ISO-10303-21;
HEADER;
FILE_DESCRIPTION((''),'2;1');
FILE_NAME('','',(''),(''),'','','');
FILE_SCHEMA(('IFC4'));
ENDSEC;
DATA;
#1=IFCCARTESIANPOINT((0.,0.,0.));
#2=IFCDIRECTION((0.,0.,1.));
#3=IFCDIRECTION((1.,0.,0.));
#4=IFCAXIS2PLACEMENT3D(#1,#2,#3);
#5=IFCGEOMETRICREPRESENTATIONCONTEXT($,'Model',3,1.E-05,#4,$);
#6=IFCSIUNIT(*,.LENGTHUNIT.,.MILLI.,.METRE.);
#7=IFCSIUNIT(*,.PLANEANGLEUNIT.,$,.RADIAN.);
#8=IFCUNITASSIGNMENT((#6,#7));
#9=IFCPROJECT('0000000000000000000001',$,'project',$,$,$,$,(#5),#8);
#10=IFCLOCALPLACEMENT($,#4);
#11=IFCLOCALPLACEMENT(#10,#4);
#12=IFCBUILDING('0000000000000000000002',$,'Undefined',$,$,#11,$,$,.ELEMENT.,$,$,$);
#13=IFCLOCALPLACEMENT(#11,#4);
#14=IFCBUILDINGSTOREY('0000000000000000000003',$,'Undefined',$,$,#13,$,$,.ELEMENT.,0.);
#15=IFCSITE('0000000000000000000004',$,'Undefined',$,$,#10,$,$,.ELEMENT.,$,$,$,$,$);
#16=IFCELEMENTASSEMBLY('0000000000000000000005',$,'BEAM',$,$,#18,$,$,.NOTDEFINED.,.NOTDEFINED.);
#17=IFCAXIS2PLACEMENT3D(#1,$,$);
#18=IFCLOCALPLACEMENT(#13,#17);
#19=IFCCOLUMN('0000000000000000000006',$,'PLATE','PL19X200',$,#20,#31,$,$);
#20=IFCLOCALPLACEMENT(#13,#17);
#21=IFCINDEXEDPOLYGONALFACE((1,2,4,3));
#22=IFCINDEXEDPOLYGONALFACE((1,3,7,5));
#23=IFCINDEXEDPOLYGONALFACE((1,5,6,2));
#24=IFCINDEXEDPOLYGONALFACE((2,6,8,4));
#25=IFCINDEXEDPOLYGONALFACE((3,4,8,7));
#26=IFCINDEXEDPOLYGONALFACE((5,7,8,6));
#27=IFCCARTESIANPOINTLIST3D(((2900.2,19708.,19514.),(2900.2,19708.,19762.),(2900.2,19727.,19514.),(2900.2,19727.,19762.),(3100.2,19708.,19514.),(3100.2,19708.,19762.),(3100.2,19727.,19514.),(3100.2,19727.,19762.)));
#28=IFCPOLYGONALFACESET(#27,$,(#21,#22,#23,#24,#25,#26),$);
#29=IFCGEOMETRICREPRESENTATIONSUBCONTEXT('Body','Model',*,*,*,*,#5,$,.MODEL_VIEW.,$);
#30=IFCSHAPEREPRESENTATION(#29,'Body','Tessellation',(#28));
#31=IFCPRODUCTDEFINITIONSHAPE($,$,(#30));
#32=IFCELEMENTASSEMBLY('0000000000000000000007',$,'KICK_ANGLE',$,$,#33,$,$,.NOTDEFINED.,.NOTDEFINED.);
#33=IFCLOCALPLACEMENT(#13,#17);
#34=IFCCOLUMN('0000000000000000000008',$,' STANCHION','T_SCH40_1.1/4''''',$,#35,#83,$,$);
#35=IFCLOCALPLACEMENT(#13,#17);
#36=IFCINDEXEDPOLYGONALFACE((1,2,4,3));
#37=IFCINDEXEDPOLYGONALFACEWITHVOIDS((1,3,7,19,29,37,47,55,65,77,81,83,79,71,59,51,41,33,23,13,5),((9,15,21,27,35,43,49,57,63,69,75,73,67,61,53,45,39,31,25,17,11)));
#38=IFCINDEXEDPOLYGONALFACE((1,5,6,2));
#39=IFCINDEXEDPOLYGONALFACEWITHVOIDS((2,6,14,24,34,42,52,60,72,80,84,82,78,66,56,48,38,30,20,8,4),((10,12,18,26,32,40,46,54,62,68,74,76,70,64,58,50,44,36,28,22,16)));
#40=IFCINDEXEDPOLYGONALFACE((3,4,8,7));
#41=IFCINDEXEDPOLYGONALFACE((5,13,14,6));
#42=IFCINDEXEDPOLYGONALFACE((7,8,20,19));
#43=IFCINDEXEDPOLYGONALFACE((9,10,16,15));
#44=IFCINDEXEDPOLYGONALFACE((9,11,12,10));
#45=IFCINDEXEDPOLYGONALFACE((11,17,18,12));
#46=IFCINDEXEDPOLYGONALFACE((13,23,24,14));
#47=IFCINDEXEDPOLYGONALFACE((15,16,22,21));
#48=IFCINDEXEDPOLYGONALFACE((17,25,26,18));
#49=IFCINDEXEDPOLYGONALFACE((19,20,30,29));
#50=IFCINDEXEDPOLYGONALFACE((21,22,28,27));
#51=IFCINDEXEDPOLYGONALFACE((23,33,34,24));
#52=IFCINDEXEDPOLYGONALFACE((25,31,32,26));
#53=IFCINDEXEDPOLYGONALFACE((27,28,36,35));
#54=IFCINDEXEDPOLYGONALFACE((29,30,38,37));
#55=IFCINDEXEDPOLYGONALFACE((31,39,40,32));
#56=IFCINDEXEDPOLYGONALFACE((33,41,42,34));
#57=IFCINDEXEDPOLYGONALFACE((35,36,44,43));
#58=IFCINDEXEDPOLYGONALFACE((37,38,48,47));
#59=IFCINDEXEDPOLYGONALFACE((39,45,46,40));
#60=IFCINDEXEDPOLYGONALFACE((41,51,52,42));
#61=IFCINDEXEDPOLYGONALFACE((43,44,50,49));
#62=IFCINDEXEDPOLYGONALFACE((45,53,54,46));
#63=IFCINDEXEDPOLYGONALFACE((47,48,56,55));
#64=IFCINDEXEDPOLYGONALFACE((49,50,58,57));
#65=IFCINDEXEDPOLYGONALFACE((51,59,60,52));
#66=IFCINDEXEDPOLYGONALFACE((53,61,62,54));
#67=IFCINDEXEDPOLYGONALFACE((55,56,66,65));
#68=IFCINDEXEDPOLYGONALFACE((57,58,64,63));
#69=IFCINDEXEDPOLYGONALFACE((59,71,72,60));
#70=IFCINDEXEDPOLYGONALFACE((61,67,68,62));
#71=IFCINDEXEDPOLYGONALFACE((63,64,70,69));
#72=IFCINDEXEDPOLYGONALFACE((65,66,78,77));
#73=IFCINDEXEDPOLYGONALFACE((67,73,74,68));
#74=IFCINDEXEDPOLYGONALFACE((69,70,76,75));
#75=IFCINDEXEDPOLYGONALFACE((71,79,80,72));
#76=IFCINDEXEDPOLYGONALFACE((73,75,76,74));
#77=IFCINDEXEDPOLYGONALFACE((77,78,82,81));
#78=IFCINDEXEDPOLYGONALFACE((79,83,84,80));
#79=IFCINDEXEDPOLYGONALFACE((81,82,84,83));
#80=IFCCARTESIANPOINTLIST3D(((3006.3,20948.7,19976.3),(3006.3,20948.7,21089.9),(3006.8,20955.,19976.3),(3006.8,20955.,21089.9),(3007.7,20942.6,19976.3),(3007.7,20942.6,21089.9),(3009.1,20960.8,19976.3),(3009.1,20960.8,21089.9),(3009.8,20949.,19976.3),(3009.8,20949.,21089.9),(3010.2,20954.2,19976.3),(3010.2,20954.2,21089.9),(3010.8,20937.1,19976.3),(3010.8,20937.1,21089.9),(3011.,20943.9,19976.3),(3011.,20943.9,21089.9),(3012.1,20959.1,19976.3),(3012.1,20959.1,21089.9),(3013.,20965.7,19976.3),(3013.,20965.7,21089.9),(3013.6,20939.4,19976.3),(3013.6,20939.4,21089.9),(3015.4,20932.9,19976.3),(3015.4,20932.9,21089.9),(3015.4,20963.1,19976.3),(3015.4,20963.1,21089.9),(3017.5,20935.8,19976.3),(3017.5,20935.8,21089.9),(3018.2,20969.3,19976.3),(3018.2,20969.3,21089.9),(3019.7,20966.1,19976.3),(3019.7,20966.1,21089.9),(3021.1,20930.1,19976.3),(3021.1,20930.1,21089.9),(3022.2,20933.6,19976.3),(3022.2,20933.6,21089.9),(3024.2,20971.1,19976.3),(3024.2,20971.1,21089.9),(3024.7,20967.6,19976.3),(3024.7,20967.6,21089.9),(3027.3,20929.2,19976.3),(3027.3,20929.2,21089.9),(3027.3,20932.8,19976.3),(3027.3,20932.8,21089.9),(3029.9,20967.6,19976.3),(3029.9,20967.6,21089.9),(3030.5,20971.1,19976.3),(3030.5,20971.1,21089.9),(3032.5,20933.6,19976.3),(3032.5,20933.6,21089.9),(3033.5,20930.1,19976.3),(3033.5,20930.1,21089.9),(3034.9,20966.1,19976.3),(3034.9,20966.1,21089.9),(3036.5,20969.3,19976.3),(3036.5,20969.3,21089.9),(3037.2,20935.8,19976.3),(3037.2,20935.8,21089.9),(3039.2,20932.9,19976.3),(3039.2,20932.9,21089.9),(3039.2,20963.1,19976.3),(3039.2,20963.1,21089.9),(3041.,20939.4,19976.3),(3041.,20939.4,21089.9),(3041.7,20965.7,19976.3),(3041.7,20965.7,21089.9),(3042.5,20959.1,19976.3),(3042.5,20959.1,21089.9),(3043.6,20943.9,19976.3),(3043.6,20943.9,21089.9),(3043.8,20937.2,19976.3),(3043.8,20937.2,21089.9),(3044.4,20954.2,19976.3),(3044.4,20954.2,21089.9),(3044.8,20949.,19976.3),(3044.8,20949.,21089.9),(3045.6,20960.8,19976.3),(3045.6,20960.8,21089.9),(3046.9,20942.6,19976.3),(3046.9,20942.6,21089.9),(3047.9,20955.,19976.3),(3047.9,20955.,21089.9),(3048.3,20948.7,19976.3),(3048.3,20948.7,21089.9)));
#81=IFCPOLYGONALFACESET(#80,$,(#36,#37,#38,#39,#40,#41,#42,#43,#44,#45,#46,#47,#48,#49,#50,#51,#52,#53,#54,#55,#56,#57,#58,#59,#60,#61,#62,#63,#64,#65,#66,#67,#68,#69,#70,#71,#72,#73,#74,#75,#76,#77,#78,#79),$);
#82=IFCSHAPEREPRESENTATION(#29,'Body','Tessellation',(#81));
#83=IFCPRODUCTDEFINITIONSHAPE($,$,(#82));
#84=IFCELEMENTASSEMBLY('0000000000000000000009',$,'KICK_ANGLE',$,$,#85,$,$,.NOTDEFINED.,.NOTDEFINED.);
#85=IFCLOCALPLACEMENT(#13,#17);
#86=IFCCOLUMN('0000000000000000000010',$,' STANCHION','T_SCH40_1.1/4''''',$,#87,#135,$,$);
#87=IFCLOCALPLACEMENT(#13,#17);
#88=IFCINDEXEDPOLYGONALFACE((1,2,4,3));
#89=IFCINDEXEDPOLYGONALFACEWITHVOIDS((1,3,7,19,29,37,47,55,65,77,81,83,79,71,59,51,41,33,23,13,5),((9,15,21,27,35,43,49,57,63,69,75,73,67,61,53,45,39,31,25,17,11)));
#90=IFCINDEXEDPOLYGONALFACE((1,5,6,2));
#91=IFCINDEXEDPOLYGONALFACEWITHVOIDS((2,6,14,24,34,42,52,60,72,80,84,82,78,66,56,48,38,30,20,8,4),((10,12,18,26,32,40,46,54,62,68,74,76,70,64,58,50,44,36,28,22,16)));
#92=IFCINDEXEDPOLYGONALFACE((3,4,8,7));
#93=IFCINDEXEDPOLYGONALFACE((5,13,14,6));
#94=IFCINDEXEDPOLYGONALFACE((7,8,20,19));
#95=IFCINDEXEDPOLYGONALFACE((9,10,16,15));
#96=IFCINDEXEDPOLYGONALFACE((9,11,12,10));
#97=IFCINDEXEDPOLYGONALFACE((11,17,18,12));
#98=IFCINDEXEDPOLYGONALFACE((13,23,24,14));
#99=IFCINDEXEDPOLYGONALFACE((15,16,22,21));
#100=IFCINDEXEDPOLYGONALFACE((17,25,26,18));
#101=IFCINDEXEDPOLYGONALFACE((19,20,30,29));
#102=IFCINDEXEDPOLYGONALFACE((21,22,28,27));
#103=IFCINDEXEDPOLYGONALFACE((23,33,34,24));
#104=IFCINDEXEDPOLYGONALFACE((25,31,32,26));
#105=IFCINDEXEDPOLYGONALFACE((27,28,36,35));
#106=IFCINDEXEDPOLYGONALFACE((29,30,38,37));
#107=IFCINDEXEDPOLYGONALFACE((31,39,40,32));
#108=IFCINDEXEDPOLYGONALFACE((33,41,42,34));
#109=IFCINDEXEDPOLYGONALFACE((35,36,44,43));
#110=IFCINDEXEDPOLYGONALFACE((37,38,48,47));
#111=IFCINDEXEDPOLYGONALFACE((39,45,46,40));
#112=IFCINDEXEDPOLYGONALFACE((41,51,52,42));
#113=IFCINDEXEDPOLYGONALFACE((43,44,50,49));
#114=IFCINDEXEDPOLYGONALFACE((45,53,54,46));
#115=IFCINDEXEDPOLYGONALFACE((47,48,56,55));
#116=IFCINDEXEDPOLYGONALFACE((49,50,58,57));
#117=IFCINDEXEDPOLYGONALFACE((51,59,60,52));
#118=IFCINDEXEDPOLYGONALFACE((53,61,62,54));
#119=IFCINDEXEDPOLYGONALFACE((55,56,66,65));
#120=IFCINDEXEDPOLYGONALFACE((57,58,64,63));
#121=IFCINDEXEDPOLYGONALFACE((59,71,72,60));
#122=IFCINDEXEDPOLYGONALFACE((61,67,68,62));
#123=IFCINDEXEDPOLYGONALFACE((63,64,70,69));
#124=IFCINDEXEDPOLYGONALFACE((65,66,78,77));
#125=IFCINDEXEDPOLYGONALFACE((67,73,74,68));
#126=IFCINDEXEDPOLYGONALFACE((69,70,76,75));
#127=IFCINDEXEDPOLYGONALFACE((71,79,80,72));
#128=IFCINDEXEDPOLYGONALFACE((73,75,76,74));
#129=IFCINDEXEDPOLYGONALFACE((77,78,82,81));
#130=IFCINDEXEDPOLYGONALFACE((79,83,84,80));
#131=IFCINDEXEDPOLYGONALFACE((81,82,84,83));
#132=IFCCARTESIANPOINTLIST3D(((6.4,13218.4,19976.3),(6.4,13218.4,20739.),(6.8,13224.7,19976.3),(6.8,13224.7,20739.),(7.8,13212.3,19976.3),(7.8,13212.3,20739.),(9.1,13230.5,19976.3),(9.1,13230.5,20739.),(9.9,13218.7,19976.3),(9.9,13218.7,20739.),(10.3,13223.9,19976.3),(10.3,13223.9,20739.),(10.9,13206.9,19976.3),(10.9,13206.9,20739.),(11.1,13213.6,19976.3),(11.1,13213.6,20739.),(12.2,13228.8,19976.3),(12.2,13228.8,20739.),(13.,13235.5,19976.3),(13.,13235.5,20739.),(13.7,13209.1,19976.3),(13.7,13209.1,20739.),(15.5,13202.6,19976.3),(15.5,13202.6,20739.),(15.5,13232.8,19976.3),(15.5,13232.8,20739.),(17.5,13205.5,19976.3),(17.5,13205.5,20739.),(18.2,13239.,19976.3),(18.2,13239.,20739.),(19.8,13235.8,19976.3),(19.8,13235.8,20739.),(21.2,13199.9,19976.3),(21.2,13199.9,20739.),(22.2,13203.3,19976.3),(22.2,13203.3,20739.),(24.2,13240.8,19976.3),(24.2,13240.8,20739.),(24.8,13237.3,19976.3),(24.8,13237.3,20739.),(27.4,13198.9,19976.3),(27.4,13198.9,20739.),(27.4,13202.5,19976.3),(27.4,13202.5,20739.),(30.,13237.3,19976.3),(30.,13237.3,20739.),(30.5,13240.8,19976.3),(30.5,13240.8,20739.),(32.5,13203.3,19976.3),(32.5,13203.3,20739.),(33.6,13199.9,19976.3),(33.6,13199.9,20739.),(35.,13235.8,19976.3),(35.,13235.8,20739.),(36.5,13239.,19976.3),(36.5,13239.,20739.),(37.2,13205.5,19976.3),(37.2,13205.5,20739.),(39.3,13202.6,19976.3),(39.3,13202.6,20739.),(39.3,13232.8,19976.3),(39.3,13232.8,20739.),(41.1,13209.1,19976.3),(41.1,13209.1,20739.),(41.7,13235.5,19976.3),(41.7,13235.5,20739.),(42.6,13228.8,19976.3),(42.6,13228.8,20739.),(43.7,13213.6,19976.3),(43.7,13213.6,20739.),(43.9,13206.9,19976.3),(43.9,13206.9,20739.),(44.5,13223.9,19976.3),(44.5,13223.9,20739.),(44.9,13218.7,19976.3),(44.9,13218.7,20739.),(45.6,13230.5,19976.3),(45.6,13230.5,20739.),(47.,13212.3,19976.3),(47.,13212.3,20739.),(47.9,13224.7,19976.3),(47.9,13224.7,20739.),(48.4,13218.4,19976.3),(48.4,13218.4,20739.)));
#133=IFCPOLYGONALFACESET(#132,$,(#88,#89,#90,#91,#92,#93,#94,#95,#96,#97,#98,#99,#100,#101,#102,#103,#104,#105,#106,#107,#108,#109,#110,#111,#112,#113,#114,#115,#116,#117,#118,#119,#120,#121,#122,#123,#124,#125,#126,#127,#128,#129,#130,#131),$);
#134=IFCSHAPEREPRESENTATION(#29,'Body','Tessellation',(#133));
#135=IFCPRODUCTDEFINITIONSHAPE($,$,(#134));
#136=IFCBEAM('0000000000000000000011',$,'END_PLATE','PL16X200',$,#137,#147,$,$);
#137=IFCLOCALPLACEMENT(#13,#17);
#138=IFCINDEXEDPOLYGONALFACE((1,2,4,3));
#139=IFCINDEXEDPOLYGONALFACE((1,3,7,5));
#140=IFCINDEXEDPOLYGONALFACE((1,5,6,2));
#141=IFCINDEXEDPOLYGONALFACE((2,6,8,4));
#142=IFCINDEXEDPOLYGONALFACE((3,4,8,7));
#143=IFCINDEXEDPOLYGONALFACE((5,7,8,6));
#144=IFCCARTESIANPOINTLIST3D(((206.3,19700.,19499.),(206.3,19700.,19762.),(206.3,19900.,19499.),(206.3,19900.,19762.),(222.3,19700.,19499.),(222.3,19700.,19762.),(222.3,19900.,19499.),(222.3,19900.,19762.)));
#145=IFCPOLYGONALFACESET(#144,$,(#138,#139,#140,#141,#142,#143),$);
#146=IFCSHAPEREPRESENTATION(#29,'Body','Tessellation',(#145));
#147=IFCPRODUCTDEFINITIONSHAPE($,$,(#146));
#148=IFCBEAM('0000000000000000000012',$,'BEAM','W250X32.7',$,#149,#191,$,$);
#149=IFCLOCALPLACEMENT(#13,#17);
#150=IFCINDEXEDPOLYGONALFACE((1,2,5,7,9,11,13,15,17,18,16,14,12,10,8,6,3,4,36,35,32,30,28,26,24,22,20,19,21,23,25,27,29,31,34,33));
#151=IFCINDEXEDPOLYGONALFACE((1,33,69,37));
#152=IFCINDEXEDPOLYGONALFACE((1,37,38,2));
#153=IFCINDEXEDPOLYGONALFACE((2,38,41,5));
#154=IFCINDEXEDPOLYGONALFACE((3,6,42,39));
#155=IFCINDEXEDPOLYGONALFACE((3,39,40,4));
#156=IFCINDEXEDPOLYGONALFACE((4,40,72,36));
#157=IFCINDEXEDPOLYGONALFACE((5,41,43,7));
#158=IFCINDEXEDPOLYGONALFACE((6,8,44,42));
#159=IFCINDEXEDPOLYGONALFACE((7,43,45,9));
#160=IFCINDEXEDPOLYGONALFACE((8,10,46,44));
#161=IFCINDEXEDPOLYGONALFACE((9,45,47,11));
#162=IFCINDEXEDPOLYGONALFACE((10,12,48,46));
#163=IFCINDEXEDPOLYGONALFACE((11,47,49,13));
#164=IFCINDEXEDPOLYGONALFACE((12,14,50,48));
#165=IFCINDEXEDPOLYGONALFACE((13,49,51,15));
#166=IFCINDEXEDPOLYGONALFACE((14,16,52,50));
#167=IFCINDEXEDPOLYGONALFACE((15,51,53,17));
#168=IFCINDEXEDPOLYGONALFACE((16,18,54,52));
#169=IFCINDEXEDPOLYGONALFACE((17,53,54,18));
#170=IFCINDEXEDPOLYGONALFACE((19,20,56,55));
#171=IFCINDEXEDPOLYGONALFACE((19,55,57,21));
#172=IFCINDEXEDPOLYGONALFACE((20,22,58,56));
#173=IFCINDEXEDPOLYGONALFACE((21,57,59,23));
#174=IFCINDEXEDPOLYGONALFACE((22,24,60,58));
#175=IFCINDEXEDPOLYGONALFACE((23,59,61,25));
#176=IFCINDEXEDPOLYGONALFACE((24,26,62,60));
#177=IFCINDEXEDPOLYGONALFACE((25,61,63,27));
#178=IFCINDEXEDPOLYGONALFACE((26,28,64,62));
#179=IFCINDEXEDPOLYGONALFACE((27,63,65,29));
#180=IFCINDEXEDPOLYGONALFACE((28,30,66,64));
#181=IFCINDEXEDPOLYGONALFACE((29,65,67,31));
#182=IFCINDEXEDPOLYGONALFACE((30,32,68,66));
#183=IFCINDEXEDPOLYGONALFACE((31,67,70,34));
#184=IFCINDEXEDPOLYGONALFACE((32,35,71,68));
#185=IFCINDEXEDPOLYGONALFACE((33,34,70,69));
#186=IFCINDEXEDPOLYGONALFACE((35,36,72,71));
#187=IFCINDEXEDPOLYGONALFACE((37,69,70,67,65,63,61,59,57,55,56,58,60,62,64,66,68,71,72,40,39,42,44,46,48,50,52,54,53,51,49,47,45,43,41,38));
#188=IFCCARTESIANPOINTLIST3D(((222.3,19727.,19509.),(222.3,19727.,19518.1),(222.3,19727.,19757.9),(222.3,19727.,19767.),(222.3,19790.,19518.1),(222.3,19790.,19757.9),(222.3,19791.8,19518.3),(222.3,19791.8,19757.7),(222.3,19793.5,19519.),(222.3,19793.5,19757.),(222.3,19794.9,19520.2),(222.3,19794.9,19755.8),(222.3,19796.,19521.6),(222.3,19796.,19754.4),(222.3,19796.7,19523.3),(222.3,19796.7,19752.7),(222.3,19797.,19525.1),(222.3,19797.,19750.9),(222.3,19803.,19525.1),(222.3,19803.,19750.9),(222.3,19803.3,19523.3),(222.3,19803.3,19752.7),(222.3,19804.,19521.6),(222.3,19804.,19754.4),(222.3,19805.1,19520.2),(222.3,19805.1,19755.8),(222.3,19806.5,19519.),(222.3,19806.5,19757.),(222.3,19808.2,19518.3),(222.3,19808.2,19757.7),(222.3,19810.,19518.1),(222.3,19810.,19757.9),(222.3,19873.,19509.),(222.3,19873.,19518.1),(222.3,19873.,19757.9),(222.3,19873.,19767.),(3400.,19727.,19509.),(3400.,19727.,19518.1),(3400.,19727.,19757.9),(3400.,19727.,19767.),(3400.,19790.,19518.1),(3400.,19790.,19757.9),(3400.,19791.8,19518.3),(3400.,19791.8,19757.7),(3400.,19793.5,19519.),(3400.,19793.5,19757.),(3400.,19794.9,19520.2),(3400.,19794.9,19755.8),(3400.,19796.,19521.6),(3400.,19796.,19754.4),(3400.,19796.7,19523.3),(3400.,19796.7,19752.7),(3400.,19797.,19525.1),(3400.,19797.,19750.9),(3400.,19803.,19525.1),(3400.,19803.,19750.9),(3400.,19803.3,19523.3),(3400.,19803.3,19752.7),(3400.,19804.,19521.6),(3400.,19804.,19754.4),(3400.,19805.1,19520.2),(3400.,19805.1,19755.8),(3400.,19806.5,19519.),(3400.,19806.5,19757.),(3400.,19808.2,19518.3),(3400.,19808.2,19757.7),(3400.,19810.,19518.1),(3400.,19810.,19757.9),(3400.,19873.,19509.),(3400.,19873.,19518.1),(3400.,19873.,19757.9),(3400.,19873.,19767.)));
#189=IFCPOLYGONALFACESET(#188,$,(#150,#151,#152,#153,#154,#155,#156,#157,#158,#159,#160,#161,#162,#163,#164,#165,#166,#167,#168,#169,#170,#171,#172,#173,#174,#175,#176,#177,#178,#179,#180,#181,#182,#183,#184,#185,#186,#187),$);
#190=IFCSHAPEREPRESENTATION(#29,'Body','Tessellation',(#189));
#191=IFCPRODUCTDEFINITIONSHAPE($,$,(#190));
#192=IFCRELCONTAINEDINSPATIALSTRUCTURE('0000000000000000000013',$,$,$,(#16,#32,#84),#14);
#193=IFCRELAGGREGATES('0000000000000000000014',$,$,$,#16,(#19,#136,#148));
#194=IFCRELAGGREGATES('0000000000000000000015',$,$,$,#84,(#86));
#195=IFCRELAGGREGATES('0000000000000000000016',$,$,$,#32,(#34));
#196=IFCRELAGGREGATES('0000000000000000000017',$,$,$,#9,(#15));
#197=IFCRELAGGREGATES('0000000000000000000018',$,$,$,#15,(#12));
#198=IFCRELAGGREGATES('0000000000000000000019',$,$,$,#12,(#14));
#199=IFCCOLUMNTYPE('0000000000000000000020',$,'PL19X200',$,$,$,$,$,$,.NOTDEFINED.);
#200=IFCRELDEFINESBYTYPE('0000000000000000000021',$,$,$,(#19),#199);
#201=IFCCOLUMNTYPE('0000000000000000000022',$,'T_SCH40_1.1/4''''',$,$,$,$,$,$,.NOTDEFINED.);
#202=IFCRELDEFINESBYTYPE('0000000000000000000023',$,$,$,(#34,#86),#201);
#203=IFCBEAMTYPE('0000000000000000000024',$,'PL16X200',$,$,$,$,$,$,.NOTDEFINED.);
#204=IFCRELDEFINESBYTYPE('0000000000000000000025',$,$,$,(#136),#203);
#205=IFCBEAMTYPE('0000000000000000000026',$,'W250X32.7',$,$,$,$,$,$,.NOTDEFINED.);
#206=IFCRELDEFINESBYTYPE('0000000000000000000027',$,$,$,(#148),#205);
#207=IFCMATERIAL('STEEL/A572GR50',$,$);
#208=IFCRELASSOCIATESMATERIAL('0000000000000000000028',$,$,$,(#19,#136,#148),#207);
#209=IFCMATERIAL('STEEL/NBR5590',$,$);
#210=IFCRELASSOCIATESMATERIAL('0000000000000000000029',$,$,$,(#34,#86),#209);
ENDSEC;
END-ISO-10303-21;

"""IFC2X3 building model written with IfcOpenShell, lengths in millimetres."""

from ifc_helpers import new_model, si_unit, frame, origin_with_axes, origin_2d_with_axis, place, context, subcontext, project, spatial, rectangle, hollow_circle, i_section, extrude, clip, halfspace, material, type_object, element, aggregate, save


model = new_model("IFC2X3")

# Units and contexts
model_context = context("Model", 3, precision=1e-05, world=origin_with_axes())
body_context = subcontext(model_context, "Body", "Model", "MODEL_VIEW")
ifc_project = project(units=[si_unit("LENGTHUNIT", "METRE", prefix="MILLI"), si_unit("PLANEANGLEUNIT", "RADIAN")], contexts=[model_context])

# Site, building, storey
site_placement = place(None, origin_with_axes())
site = spatial("IfcSite", under=ifc_project, at=site_placement, Name="Undefined", CompositionType="ELEMENT")
building_placement = place(site_placement, origin_with_axes())
building = spatial("IfcBuilding", under=site, at=building_placement, Name="Undefined", CompositionType="ELEMENT")
storey_placement = place(building_placement, origin_with_axes())
storey = spatial("IfcBuildingStorey", under=building, at=storey_placement, Name="Undefined", CompositionType="ELEMENT", Elevation=0.0)

# Element assemblies, columns
assembly_1_placement = place(storey_placement, origin_with_axes())
assembly_1 = element("IfcElementAssembly", 1, at=assembly_1_placement, inside=storey, Name="BEAM", AssemblyPlace="NOTDEFINED", PredefinedType="NOTDEFINED")
ifc_material_1 = material(Name="STEEL/A572GR50")
column_type_1 = type_object("IfcColumnType", Name="PL19X200", PredefinedType="NOTDEFINED")
column_1_placement = place(assembly_1_placement, frame((3000.2, 19717.5, 19514.0), z_axis=(0.0, 0.0, 1.0), x_axis=(-1.0, 0.0, 0.0)))
column_1 = element("IfcColumn", 2, at=column_1_placement, type_object=column_type_1, material=ifc_material_1, Name="PLATE", Description="PL19X200", context=body_context, shape_type="SweptSolid", body=[
    extrude(rectangle(XDim=19.0, YDim=200.0, at=origin_2d_with_axis()), frame((0.0, 0.0, 248.0), z_axis=(0.0, 0.0, -1.0), x_axis=(0.0, 1.0, 0.0)), (0.0, 0.0, 1.0), 248.0),
])
assembly_2_placement = place(storey_placement, origin_with_axes())
assembly_2 = element("IfcElementAssembly", 3, at=assembly_2_placement, inside=storey, Name="KICK_ANGLE", AssemblyPlace="NOTDEFINED", PredefinedType="NOTDEFINED")
ifc_material_2 = material(Name="STEEL/NBR5590")
column_type_2 = type_object("IfcColumnType", Name="T_SCH40_1.1/4''", PredefinedType="NOTDEFINED")
column_2_placement = place(assembly_2_placement, frame((3027.3, 20950.3, 19976.3), z_axis=(0.0, 0.0, 1.0), x_axis=(-1.0, -0.000052, 0.0)))
column_2 = element("IfcColumn", 4, at=column_2_placement, type_object=column_type_2, material=ifc_material_2, Name=" STANCHION", Description="T_SCH40_1.1/4''", context=body_context, shape_type="SweptSolid", body=[
    extrude(hollow_circle(Radius=21.1, WallThickness=3.6, at=origin_2d_with_axis()), frame((0.0, 0.0, 1113.6), z_axis=(0.0, 0.0, -1.0), x_axis=(0.0, 1.0, 0.0)), (0.0, 0.0, 1.0), 1113.6),
])
assembly_3_placement = place(storey_placement, origin_with_axes())
assembly_3 = element("IfcElementAssembly", 5, at=assembly_3_placement, inside=storey, Name="KICK_ANGLE", AssemblyPlace="NOTDEFINED", PredefinedType="NOTDEFINED")
column_3_placement = place(assembly_3_placement, frame((27.4, 13220.0, 19976.3), z_axis=(0.0, 0.0, 1.0), x_axis=(-1.0, 0.0, 0.0)))
column_3 = element("IfcColumn", 6, at=column_3_placement, type_object=column_type_2, material=ifc_material_2, Name=" STANCHION", Description="T_SCH40_1.1/4''", context=body_context, shape_type="Clipping", body=[
    clip(extrude(hollow_circle(Radius=21.1, WallThickness=3.6, at=origin_2d_with_axis()), frame((0.0, 0.0, 1113.6), z_axis=(0.0, 0.0, -1.0), x_axis=(0.0, 1.0, 0.0)), (0.0, 0.0, 1.0), 1113.6), halfspace(frame((0.0, 0.0, 762.7), z_axis=(0.0, 0.0, 1.0), x_axis=(0.0, 1.0, 0.0)), False)),
])

# Beams
beam_type_1 = type_object("IfcBeamType", Name="PL16X200", PredefinedType="NOTDEFINED")
beam_1_placement = place(assembly_1_placement, frame((214.3, 19800.0, 19762.0), z_axis=(0.0, -1.0, 0.0), x_axis=(0.0, 0.0, -1.0)))
beam_1 = element("IfcBeam", 7, at=beam_1_placement, type_object=beam_type_1, material=ifc_material_1, Name="END_PLATE", Description="PL16X200", context=body_context, shape_type="SweptSolid", body=[
    extrude(rectangle(XDim=16.0, YDim=200.0, at=origin_2d_with_axis()), frame((263.0, 0.0, 0.0), z_axis=(-1.0, 0.0, 0.0), x_axis=(0.0, -1.0, 0.0)), (0.0, 0.0, 1.0), 263.0),
])
beam_type_2 = type_object("IfcBeamType", Name="W250X32.7", PredefinedType="NOTDEFINED")
beam_2_placement = place(assembly_1_placement, frame((3400.0, 19800.0, 19638.0), z_axis=(0.0, 0.0, 1.0), x_axis=(-1.0, 0.0, 0.0)))
beam_2 = element("IfcBeam", 8, at=beam_2_placement, type_object=beam_type_2, material=ifc_material_1, Name="BEAM", Description="W250X32.7", context=body_context, shape_type="Clipping", body=[
    clip(extrude(i_section(OverallWidth=146.0, OverallDepth=258.0, WebThickness=6.1, FlangeThickness=9.1, FilletRadius=7.0, at=origin_2d_with_axis()), frame((3400.0, 0.0, 0.0), z_axis=(-1.0, 0.0, 0.0), x_axis=(0.0, -1.0, 0.0)), (0.0, 0.0, 1.0), 3400.0), halfspace(frame((3177.7, 0.0, -250.0), z_axis=(-1.0, 0.0, 0.0), x_axis=(0.0, 1.0, 0.0)), True)),
])

aggregate(assembly_1, [column_1, beam_1, beam_2])

aggregate(assembly_3, [column_3])
aggregate(assembly_2, [column_2])

save(model, "model.ifc")
